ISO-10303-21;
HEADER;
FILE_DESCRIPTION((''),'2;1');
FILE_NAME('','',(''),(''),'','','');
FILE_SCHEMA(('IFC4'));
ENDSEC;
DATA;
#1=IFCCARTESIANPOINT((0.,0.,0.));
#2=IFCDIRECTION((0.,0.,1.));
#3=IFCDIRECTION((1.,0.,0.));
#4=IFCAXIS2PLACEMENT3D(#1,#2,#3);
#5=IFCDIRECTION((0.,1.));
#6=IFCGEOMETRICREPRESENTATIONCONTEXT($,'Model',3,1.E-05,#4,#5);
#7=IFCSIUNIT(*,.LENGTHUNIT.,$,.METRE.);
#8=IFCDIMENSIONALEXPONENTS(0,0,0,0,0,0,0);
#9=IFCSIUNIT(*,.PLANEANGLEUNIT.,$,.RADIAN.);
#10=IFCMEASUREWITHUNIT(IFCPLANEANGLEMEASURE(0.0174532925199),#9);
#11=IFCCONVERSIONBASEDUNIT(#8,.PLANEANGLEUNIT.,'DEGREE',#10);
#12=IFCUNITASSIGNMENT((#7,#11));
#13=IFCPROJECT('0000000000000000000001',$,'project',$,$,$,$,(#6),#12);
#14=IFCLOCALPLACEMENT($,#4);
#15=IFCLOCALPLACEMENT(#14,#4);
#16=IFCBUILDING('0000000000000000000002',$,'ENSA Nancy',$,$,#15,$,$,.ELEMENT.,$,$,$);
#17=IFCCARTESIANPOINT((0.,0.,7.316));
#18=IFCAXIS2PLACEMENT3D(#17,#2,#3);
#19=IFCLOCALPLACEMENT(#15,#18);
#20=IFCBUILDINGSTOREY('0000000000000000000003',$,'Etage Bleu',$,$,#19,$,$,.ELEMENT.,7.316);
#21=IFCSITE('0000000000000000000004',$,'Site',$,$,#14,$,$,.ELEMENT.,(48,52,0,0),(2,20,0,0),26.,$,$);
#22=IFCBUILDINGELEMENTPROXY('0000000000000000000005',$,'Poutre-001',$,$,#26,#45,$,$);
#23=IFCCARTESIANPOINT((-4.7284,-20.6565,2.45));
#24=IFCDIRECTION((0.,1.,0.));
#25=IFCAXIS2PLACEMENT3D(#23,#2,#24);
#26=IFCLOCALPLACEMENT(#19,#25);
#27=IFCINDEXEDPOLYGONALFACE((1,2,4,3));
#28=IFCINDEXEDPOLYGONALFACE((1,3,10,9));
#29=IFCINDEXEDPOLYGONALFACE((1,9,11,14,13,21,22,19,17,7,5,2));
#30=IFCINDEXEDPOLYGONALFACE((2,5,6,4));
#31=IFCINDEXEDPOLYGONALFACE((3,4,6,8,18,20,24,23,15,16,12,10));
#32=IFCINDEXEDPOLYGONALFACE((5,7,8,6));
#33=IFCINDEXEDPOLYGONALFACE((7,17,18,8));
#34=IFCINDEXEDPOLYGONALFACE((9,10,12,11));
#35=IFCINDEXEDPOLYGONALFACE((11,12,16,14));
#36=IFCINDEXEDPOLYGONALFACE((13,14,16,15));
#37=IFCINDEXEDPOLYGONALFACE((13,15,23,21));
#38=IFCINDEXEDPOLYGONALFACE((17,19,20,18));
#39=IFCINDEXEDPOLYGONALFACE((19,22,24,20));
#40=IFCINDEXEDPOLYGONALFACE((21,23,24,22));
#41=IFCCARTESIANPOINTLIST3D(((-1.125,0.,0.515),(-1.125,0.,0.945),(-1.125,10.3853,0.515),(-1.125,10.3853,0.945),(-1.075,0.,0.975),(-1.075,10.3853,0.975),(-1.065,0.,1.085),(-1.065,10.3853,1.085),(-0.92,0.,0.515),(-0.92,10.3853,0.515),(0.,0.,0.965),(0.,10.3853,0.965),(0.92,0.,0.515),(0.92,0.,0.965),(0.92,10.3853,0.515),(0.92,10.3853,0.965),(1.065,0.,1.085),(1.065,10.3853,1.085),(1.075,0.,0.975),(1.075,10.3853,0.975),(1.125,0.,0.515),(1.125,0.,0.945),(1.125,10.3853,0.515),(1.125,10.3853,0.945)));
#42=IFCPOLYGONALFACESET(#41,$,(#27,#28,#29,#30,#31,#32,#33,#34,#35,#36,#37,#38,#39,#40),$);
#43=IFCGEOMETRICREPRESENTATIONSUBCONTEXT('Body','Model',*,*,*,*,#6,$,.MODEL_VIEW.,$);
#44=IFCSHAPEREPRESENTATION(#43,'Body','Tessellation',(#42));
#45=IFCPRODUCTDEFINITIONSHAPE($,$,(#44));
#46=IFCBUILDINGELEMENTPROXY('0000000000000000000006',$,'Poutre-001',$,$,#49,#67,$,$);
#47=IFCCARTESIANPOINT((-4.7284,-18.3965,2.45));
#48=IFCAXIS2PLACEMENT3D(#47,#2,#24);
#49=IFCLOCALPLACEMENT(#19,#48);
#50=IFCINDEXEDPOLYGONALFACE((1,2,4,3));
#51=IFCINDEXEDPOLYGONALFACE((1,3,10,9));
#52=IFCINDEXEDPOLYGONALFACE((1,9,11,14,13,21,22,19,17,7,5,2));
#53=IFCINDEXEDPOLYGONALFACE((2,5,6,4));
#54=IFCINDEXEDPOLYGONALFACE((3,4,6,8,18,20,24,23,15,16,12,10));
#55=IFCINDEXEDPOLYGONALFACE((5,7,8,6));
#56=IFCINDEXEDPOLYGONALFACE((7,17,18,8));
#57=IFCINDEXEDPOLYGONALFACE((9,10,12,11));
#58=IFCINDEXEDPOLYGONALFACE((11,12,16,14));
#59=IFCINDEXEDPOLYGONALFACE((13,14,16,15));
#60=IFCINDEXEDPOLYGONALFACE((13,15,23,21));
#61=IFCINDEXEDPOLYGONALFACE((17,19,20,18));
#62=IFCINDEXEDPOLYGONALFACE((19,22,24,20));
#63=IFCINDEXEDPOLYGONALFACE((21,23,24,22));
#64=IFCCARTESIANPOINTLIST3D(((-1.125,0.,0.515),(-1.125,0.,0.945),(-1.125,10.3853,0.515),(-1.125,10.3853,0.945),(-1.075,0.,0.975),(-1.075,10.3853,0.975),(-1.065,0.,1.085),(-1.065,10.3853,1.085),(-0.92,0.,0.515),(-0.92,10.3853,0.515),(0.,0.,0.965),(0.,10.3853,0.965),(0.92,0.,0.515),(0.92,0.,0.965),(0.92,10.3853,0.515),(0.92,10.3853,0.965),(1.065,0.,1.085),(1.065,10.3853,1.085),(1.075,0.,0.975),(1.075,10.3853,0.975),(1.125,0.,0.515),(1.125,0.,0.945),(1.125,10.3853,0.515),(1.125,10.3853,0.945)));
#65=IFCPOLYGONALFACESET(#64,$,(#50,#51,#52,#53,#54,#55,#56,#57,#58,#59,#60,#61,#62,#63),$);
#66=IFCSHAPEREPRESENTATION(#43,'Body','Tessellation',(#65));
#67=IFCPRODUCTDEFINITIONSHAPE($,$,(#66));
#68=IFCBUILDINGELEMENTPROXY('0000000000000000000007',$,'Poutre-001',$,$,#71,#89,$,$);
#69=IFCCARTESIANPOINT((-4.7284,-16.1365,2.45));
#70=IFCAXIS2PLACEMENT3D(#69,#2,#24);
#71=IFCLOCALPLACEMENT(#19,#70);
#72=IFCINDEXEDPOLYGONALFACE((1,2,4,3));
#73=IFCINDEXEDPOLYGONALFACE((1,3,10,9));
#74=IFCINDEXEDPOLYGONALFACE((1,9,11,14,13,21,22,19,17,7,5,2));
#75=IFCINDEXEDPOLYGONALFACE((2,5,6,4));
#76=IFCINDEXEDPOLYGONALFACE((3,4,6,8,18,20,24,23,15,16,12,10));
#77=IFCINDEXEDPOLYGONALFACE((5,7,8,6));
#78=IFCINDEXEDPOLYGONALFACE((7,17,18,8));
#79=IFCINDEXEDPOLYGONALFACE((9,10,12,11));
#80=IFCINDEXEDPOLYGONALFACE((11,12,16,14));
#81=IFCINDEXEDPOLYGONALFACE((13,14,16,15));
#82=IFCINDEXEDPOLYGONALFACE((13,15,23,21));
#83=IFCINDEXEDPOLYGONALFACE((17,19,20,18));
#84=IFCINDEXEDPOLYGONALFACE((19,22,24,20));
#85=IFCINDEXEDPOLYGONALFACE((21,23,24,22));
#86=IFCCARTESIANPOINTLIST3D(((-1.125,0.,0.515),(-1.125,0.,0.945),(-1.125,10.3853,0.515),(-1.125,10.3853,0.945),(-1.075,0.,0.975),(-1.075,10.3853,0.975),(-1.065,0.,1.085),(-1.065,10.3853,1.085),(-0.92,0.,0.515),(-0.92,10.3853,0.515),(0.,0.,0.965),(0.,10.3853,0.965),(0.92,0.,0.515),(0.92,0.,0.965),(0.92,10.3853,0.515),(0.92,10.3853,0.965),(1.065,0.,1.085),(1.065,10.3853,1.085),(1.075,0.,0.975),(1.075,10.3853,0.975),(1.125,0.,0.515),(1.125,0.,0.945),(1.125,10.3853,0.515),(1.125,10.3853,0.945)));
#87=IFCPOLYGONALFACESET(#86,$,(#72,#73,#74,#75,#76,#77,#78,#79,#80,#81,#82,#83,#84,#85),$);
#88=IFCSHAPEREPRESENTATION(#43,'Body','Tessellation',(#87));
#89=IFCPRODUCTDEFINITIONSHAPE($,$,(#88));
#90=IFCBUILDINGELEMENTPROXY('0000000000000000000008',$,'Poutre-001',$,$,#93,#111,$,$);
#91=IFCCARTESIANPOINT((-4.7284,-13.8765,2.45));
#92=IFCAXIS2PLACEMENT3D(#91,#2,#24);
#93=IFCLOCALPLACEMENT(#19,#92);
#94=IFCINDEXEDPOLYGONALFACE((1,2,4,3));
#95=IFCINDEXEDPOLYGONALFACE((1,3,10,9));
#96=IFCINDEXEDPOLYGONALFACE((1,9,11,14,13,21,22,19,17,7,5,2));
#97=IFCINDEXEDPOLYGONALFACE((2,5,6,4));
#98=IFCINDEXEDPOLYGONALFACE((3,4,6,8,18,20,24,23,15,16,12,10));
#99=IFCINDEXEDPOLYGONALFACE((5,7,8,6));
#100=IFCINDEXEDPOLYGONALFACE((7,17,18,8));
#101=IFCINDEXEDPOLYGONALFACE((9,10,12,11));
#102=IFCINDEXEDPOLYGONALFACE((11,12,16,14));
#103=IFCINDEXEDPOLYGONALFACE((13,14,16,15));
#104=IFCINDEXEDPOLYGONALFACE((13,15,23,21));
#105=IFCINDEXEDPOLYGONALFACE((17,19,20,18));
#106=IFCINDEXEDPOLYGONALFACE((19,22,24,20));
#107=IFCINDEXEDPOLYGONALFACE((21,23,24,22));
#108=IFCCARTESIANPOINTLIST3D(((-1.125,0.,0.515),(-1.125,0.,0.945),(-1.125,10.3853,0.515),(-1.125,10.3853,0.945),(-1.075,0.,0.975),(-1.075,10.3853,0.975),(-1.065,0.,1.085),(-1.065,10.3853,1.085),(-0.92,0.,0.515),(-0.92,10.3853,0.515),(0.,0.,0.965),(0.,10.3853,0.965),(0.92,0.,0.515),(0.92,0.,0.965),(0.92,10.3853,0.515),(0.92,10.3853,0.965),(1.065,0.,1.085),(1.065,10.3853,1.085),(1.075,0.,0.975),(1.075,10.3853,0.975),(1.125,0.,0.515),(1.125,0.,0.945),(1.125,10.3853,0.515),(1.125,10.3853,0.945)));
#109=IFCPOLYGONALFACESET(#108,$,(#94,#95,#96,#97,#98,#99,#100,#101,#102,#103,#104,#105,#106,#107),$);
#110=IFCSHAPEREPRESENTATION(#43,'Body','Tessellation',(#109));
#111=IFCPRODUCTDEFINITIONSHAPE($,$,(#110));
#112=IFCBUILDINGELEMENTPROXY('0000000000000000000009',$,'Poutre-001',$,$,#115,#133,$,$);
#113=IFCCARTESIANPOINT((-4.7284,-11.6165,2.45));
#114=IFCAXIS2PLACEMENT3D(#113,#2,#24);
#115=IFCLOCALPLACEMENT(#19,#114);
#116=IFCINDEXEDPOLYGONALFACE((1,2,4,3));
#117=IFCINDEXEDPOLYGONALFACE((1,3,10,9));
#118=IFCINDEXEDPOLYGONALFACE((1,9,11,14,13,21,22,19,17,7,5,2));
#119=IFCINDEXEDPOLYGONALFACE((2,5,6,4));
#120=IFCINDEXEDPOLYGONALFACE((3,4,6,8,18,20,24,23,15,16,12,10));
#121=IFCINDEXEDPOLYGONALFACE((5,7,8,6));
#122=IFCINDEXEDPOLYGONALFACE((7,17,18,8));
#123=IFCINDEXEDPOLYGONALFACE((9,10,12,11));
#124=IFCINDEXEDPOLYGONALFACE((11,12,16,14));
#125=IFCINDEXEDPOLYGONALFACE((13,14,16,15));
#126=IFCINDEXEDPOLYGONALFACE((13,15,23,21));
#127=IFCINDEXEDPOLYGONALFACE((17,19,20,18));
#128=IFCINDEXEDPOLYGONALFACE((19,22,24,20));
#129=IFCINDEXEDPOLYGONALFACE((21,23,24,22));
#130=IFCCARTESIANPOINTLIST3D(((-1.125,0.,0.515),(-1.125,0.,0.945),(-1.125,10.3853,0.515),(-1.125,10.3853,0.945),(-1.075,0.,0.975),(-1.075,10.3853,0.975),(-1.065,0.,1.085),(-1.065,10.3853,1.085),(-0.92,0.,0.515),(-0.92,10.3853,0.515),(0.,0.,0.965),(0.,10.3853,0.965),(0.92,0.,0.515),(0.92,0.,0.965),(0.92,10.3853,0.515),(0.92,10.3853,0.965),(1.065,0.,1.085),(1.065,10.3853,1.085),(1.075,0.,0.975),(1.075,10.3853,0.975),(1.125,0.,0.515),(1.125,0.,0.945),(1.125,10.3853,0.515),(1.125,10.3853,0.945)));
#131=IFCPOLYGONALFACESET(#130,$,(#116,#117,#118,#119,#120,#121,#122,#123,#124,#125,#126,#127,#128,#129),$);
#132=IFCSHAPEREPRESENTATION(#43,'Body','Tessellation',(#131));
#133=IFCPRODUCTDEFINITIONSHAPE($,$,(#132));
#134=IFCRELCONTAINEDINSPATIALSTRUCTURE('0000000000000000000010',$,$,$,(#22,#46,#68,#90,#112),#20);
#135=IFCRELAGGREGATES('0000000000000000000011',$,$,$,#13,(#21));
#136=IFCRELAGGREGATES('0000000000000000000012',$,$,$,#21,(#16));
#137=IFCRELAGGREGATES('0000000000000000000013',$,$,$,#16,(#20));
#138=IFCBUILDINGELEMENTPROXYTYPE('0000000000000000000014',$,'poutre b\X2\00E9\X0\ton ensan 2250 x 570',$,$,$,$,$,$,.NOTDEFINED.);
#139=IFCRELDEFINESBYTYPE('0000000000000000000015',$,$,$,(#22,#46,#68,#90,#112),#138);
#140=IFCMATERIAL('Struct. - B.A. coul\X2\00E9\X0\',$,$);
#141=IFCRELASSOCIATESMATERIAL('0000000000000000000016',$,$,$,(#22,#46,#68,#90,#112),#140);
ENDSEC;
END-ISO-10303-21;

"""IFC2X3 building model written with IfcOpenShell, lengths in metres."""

from ifc_helpers import new_model, entity, si_unit, converted_unit, direction, frame, origin_with_axes, place, context, subcontext, project, spatial, polyline, outline, extrude, material, type_object, element, save


model = new_model("IFC2X3")

# Units and contexts
model_context = context("Model", 3, precision=1e-05, world=origin_with_axes(), true_north=direction((0.0, 1.0)))
body_context = subcontext(model_context, "Body", "Model", "MODEL_VIEW")
ifc_project = project(units=[si_unit("LENGTHUNIT", "METRE"), converted_unit("PLANEANGLEUNIT", "DEGREE", entity("IfcPlaneAngleMeasure", 0.0174532925199), si_unit("PLANEANGLEUNIT", "RADIAN"), dimensions=[0, 0, 0, 0, 0, 0, 0])], contexts=[model_context])

# Site, building, storey
site_placement = place(None, origin_with_axes())
site = spatial("IfcSite", under=ifc_project, at=site_placement, Name="Site", CompositionType="ELEMENT", RefLatitude=(48, 52, 0, 0), RefLongitude=(2, 20, 0, 0), RefElevation=26.0)
building_placement = place(site_placement, origin_with_axes())
building = spatial("IfcBuilding", under=site, at=building_placement, Name="ENSA Nancy", CompositionType="ELEMENT")
storey_placement = place(building_placement, frame((0.0, 0.0, 7.316), z_axis=(0.0, 0.0, 1.0), x_axis=(1.0, 0.0, 0.0)))
storey = spatial("IfcBuildingStorey", under=building, at=storey_placement, Name="Etage Bleu", CompositionType="ELEMENT", Elevation=7.316)

# Building element proxies
ifc_material_1 = material(Name="Struct. - B.A. coulé")
building_element_proxy_type_1 = type_object("IfcBuildingElementProxyType", Name="poutre béton ensan 2250 x 570", PredefinedType="NOTDEFINED")
for number, where, z_axis, x_axis, name in (
    (1, (-4.7284, -20.6565, 2.45), (0.0, 0.0, 1.0), (0.0, 1.0, 0.0), "Poutre-001"),
    (2, (-4.7284, -18.3965, 2.45), (0.0, 0.0, 1.0), (0.0, 1.0, 0.0), "Poutre-001"),
    (3, (-4.7284, -16.1365, 2.45), (0.0, 0.0, 1.0), (0.0, 1.0, 0.0), "Poutre-001"),
    (4, (-4.7284, -13.8765, 2.45), (0.0, 0.0, 1.0), (0.0, 1.0, 0.0), "Poutre-001"),
    (5, (-4.7284, -11.6165, 2.45), (0.0, 0.0, 1.0), (0.0, 1.0, 0.0), "Poutre-001"),
):
    element("IfcBuildingElementProxy", number, at=place(storey_placement, frame(where, z_axis=z_axis, x_axis=x_axis)), inside=storey, type_object=building_element_proxy_type_1, material=ifc_material_1, Name=name, context=body_context, shape_type="SweptSolid", body=[
        extrude(outline(polyline([(-1.065, 1.085), (-1.075, 0.975), (-1.125, 0.945), (-1.125, 0.515), (-0.92, 0.515), (0.0, 0.965), (0.92, 0.965), (0.92, 0.515), (1.125, 0.515), (1.125, 0.945), (1.075, 0.975), (1.065, 1.085), (-1.065, 1.085)])), frame((0.0, 10.3853, 0.0), z_axis=(0.0, -1.0, 0.0), x_axis=(1.0, 0.0, 0.0)), (0.0, 0.0, 1.0), 10.3853),
    ])

save(model, "model.ifc")
